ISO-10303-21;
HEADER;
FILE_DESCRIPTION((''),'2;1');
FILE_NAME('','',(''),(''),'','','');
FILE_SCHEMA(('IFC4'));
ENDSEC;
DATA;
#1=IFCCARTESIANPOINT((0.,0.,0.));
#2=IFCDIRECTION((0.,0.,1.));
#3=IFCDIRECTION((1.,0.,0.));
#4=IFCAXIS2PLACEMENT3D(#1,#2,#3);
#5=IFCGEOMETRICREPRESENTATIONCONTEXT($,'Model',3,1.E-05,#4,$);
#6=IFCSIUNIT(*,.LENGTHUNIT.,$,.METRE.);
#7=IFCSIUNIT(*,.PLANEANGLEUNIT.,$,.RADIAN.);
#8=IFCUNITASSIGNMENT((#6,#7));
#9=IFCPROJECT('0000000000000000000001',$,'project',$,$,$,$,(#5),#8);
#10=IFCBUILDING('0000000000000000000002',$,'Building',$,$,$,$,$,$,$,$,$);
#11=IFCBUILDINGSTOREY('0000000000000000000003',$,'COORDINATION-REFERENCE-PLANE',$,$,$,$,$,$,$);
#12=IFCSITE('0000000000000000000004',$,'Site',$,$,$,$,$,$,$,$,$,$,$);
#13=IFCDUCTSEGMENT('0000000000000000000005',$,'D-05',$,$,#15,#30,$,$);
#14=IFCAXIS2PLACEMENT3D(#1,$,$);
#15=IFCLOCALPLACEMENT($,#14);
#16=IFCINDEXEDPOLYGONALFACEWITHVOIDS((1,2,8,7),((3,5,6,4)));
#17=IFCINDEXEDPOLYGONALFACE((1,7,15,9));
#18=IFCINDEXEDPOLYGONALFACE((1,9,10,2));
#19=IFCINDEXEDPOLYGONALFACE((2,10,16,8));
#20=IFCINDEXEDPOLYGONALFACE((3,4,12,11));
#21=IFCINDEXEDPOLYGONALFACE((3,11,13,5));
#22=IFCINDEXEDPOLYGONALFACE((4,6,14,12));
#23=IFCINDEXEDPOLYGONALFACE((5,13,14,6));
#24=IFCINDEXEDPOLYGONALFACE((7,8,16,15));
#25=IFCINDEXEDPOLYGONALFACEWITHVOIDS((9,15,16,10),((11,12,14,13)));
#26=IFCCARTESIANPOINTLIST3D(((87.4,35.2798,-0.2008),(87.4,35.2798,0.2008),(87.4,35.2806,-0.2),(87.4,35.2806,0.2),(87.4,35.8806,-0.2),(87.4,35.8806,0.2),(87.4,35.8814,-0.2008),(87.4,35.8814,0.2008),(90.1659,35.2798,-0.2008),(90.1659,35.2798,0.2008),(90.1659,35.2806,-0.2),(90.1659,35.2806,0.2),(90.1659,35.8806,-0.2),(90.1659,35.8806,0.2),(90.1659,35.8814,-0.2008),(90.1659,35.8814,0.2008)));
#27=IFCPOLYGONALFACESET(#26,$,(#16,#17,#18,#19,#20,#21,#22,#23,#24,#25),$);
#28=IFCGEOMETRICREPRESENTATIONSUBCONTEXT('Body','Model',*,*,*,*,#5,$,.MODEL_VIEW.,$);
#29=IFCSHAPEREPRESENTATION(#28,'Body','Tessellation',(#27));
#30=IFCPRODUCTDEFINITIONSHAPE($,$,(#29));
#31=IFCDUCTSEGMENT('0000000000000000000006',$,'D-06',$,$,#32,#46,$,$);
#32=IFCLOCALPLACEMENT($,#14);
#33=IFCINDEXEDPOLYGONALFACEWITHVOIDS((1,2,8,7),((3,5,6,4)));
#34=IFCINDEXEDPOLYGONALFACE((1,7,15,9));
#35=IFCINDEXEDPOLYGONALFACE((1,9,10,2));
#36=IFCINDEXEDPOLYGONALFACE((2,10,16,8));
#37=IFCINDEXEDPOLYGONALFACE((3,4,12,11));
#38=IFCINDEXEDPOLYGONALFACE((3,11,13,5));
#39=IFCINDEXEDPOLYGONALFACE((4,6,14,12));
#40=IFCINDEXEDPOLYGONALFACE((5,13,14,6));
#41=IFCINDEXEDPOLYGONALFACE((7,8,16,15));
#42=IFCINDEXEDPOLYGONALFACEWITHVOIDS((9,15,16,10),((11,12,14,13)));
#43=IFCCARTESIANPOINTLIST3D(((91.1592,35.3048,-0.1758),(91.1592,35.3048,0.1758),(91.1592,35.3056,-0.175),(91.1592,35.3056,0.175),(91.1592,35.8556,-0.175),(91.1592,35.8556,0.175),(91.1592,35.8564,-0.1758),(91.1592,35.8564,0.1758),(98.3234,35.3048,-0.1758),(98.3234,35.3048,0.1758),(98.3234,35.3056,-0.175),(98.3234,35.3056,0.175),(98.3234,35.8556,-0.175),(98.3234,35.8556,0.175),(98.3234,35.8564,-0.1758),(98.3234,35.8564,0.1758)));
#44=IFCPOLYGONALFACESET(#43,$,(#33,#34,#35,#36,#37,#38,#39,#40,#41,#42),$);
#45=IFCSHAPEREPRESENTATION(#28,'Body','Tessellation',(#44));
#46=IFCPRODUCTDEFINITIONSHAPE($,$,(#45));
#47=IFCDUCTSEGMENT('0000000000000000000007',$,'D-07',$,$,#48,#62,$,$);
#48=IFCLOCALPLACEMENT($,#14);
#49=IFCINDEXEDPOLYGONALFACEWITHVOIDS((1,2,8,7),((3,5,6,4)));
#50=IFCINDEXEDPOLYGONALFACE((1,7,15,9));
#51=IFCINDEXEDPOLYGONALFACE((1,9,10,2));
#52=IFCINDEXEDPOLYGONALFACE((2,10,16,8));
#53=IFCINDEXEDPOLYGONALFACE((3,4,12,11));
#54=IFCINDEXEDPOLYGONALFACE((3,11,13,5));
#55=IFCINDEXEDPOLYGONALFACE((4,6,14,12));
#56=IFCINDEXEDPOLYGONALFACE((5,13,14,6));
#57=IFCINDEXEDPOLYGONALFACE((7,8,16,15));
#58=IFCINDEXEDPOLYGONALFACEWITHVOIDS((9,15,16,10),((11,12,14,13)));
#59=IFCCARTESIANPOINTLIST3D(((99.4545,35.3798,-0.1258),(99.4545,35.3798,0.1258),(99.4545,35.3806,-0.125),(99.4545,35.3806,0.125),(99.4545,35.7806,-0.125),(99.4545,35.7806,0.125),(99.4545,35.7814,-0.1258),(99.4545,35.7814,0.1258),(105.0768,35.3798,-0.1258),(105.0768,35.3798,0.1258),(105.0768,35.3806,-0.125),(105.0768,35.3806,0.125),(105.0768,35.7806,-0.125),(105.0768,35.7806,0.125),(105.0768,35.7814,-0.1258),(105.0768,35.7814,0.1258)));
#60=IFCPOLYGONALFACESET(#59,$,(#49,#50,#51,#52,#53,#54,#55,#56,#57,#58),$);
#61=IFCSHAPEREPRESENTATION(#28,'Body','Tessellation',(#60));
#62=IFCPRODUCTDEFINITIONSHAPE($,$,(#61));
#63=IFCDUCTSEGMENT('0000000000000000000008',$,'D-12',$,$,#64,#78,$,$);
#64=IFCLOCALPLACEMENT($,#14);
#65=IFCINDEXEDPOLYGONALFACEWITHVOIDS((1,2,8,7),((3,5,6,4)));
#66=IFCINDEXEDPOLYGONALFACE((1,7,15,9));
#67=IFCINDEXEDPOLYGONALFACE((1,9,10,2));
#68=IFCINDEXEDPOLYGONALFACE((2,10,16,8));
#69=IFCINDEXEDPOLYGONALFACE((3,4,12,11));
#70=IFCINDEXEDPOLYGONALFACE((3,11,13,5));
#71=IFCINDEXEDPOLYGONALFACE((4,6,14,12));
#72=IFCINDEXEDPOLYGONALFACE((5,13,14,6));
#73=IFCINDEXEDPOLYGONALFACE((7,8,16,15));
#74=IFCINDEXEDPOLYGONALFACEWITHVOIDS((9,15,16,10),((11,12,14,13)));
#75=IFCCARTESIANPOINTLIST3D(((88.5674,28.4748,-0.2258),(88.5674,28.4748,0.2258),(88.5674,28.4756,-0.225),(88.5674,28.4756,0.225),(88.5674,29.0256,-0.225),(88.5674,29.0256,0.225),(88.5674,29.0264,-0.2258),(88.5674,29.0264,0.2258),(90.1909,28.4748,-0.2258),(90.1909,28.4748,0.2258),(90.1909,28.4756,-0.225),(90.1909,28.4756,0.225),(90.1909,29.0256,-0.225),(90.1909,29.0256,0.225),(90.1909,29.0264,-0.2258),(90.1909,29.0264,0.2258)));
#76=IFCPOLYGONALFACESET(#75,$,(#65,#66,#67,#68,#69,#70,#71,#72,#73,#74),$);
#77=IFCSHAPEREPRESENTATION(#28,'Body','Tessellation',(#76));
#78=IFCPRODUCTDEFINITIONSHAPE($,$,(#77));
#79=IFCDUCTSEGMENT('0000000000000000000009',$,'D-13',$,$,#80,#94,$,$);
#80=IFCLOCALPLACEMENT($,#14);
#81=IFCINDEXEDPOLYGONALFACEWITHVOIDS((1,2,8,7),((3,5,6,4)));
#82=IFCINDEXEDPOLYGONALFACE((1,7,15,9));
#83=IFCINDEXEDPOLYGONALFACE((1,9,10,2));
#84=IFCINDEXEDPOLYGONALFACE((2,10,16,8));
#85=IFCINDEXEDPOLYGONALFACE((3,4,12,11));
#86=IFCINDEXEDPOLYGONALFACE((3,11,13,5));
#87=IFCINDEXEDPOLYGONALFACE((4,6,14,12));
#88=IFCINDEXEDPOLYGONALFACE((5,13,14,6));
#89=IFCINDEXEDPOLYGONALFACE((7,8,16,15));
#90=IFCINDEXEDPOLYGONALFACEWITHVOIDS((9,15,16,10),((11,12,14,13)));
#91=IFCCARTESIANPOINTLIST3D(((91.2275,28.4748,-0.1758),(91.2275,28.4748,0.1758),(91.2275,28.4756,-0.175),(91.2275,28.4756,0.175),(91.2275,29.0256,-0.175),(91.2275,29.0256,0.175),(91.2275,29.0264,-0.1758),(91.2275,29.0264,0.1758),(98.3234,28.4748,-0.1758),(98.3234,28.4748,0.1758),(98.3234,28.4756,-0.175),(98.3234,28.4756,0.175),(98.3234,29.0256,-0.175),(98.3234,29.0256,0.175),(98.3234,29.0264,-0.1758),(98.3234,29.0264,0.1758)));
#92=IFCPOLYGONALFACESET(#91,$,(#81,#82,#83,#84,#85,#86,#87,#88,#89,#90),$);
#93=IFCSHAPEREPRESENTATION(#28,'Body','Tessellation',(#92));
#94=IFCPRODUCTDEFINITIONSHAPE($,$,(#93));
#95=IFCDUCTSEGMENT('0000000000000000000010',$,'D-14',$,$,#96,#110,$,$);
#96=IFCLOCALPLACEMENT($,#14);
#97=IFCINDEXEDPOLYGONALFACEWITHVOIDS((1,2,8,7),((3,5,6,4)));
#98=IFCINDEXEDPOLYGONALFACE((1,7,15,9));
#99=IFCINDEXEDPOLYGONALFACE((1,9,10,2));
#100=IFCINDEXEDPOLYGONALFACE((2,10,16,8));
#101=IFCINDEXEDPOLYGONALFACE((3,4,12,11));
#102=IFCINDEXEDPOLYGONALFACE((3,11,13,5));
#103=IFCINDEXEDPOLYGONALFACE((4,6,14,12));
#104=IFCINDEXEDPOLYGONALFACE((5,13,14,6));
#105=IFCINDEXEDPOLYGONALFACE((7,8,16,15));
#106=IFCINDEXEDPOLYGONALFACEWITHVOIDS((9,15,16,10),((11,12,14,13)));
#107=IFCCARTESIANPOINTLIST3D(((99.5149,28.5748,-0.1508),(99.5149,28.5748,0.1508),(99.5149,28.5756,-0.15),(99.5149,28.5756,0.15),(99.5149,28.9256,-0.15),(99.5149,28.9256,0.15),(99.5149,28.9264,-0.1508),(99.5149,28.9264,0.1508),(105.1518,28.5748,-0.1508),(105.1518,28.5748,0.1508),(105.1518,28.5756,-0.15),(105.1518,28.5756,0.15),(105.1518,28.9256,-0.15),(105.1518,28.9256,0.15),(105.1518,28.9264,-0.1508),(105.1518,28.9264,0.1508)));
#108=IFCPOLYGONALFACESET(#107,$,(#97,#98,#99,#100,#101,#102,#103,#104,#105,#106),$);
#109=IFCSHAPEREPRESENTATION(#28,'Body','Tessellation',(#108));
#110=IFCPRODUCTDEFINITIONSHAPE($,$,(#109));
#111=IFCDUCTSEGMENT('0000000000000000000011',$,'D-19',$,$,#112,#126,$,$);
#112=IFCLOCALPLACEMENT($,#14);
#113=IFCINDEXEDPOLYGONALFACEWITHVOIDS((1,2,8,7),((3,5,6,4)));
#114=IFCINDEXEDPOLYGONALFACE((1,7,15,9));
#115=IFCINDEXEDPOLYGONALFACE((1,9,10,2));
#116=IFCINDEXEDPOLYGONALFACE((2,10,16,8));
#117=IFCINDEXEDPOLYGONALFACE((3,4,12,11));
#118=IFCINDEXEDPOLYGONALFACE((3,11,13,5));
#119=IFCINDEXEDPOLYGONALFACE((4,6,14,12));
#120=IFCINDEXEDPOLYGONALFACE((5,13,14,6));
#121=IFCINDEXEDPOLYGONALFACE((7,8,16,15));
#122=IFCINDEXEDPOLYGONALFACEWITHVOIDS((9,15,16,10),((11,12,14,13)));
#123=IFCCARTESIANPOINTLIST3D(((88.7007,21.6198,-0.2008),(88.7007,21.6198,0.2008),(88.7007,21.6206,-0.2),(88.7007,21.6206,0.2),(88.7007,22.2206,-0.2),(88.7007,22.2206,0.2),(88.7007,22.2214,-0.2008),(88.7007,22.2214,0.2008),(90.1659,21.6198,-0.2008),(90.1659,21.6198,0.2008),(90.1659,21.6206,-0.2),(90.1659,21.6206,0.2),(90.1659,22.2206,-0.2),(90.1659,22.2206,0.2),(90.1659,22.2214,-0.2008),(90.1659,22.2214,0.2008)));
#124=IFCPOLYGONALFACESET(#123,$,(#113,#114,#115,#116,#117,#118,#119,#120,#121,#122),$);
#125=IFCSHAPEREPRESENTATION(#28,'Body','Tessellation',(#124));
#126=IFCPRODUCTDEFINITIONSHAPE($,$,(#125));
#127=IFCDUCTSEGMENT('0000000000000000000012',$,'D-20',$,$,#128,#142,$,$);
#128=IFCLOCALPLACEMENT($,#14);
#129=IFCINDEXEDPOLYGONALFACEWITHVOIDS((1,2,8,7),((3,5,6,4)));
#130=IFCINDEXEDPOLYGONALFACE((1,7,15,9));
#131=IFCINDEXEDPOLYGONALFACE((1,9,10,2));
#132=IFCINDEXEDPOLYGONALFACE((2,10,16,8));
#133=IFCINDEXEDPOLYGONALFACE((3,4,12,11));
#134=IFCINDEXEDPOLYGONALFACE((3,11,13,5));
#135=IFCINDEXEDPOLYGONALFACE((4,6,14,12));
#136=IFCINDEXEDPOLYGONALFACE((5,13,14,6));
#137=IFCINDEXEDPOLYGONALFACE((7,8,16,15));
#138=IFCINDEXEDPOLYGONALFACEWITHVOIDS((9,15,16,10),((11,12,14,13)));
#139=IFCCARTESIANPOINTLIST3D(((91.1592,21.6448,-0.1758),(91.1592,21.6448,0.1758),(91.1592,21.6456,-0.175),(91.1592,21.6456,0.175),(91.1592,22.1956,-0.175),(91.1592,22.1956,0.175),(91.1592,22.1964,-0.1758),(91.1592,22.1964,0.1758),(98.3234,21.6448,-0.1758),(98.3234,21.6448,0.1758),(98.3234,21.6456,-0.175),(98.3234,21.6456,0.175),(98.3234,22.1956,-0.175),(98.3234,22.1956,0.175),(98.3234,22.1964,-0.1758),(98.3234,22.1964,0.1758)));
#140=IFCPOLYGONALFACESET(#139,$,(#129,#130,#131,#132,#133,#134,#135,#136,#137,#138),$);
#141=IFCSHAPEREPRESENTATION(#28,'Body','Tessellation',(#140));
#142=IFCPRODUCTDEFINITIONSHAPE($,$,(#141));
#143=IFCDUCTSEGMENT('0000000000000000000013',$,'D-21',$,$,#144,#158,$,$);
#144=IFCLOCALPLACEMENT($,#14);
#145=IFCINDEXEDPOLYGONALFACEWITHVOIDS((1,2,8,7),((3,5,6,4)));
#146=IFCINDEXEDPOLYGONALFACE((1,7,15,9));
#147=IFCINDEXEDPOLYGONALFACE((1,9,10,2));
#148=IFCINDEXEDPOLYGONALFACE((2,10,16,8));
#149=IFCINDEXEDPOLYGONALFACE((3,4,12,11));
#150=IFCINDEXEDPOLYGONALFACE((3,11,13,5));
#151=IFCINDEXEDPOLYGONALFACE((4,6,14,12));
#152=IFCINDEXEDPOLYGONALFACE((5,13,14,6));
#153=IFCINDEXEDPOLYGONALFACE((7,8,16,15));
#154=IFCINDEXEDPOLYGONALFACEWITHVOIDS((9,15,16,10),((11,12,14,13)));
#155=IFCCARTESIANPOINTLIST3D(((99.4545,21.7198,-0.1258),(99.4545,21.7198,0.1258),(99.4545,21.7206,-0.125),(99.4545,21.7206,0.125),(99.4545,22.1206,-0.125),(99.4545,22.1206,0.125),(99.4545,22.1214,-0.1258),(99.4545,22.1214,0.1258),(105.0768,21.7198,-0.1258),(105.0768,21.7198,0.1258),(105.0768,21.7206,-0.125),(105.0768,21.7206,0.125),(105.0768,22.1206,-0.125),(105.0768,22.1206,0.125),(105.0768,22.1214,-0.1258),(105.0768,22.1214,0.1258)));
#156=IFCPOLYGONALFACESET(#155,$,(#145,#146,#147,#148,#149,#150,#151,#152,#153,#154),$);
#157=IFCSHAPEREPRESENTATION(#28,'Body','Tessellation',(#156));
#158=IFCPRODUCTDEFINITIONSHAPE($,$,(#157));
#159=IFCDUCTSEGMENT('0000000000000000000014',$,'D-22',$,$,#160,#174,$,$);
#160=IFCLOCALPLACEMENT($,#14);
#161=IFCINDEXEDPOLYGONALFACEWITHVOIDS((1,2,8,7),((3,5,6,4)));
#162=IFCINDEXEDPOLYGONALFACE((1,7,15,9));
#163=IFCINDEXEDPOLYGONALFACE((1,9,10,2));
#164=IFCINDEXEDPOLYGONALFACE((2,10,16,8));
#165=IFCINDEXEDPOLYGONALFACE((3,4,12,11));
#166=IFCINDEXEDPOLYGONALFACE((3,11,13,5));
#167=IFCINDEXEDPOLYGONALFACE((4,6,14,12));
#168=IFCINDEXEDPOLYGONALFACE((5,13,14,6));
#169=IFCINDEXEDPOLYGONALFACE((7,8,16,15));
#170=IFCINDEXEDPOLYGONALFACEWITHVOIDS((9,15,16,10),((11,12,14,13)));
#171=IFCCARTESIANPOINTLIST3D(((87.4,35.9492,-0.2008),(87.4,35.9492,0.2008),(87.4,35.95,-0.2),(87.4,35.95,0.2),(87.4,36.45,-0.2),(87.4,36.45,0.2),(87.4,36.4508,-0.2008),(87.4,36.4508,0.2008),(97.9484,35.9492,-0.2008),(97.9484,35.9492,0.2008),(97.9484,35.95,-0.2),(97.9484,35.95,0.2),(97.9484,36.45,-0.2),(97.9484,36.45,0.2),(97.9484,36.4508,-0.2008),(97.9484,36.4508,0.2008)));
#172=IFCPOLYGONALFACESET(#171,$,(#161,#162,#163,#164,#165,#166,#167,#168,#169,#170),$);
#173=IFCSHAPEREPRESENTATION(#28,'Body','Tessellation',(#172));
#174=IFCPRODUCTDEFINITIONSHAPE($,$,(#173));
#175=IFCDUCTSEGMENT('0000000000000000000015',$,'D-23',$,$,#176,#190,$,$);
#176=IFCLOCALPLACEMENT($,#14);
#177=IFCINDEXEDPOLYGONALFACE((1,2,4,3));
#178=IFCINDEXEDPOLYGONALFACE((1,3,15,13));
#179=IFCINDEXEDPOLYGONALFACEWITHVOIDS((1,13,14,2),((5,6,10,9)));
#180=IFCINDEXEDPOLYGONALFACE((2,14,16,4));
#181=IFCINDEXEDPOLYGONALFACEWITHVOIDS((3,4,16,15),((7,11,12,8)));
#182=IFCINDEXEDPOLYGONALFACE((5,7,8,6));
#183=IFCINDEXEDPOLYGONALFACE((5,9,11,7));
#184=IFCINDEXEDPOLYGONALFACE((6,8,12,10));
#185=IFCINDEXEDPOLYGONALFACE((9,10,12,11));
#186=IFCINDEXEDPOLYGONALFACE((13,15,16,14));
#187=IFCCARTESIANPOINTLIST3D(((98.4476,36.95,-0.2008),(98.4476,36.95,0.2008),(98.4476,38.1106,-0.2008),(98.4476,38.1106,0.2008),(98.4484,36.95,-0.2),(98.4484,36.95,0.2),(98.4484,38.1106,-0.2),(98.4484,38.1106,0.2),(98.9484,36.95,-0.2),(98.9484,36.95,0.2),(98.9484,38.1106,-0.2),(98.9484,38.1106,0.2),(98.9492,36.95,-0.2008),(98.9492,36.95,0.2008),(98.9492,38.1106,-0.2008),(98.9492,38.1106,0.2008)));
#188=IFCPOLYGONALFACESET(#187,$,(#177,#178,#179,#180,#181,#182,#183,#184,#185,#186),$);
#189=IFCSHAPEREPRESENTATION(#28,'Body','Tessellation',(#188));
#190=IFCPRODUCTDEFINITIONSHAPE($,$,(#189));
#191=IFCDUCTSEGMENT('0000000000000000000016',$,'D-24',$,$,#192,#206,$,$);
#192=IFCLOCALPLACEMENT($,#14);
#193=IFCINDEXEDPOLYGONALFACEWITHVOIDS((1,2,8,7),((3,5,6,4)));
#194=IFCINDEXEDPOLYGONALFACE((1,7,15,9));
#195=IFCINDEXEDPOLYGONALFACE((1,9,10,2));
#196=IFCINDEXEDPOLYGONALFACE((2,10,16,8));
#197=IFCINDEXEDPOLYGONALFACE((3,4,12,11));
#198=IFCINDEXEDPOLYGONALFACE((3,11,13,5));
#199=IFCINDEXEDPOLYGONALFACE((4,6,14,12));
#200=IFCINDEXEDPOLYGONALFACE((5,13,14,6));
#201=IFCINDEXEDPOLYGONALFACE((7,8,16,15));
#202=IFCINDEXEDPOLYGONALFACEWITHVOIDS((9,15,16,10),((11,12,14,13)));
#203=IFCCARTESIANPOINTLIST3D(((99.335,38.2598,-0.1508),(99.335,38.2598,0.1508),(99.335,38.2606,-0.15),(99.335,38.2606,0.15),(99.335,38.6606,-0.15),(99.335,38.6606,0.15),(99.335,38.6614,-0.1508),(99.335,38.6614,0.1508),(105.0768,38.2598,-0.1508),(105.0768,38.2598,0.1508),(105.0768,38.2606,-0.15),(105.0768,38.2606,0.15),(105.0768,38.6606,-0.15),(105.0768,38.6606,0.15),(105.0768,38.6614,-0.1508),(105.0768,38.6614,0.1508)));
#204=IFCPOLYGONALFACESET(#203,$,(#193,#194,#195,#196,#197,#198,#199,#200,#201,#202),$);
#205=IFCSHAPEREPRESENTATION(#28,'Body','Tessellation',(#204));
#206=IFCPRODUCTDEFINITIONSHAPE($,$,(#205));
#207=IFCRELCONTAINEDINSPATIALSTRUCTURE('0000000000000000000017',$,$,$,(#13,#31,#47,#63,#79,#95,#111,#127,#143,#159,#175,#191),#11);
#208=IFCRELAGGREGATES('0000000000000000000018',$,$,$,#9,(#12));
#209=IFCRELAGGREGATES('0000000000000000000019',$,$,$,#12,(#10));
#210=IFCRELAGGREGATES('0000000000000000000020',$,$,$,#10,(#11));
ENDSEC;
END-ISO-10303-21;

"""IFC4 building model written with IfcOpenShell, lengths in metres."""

from ifc_helpers import new_model, si_unit, frame, origin, origin_with_axes, place, context, subcontext, project, spatial, hollow_rectangle, extrude, element, save


model = new_model("IFC4")

# Units and contexts
model_context = context("Model", 3, precision=1e-05, world=origin_with_axes())
body_context = subcontext(model_context, "Body", "Model", "MODEL_VIEW")
ifc_project = project(units=[si_unit("LENGTHUNIT", "METRE"), si_unit("PLANEANGLEUNIT", "RADIAN")], contexts=[model_context])

# Site, building, storey
site = spatial("IfcSite", under=ifc_project, Name="Site")
building = spatial("IfcBuilding", under=site, Name="Building")
storey = spatial("IfcBuildingStorey", under=building, Name="COORDINATION-REFERENCE-PLANE")

# Duct segments
duct_segment_1_placement = place(None, frame((87.4, 35.5806, 0.0), z_axis=(1.0, 0.0, 0.0), x_axis=(0.0, 1.0, 0.0)))
element("IfcDuctSegment", 1, at=duct_segment_1_placement, inside=storey, Name="D-05", context=body_context, shape_type="SweptSolid", body=[
    extrude(hollow_rectangle(XDim=0.6016, YDim=0.4016, WallThickness=0.0008), origin(), (0.0, 0.0, 1.0), 2.7659),
])
duct_segment_2_placement = place(None, frame((91.1592, 35.5806, 0.0), z_axis=(1.0, 0.0, 0.0), x_axis=(0.0, 1.0, 0.0)))
element("IfcDuctSegment", 2, at=duct_segment_2_placement, inside=storey, Name="D-06", context=body_context, shape_type="SweptSolid", body=[
    extrude(hollow_rectangle(XDim=0.5516, YDim=0.3516, WallThickness=0.0008), origin(), (0.0, 0.0, 1.0), 7.1642),
])
duct_segment_3_placement = place(None, frame((99.4545, 35.5806, 0.0), z_axis=(1.0, 0.0, 0.0), x_axis=(0.0, 1.0, 0.0)))
element("IfcDuctSegment", 3, at=duct_segment_3_placement, inside=storey, Name="D-07", context=body_context, shape_type="SweptSolid", body=[
    extrude(hollow_rectangle(XDim=0.4016, YDim=0.2516, WallThickness=0.0008), origin(), (0.0, 0.0, 1.0), 5.6223),
])
duct_segment_4_placement = place(None, frame((88.5674, 28.7506, 0.0), z_axis=(1.0, 0.0, 0.0), x_axis=(0.0, 1.0, 0.0)))
element("IfcDuctSegment", 4, at=duct_segment_4_placement, inside=storey, Name="D-12", context=body_context, shape_type="SweptSolid", body=[
    extrude(hollow_rectangle(XDim=0.5516, YDim=0.4516, WallThickness=0.0008), origin(), (0.0, 0.0, 1.0), 1.6235),
])
duct_segment_5_placement = place(None, frame((91.2275, 28.7506, 0.0), z_axis=(1.0, 0.0, 0.0), x_axis=(0.0, 1.0, 0.0)))
element("IfcDuctSegment", 5, at=duct_segment_5_placement, inside=storey, Name="D-13", context=body_context, shape_type="SweptSolid", body=[
    extrude(hollow_rectangle(XDim=0.5516, YDim=0.3516, WallThickness=0.0008), origin(), (0.0, 0.0, 1.0), 7.0959),
])
duct_segment_6_placement = place(None, frame((99.5149, 28.7506, 0.0), z_axis=(1.0, 0.0, 0.0), x_axis=(0.0, 1.0, 0.0)))
element("IfcDuctSegment", 6, at=duct_segment_6_placement, inside=storey, Name="D-14", context=body_context, shape_type="SweptSolid", body=[
    extrude(hollow_rectangle(XDim=0.3516, YDim=0.3016, WallThickness=0.0008), origin(), (0.0, 0.0, 1.0), 5.6369),
])
duct_segment_7_placement = place(None, frame((88.7007, 21.9206, 0.0), z_axis=(1.0, 0.0, 0.0), x_axis=(0.0, 1.0, 0.0)))
element("IfcDuctSegment", 7, at=duct_segment_7_placement, inside=storey, Name="D-19", context=body_context, shape_type="SweptSolid", body=[
    extrude(hollow_rectangle(XDim=0.6016, YDim=0.4016, WallThickness=0.0008), origin(), (0.0, 0.0, 1.0), 1.4652),
])
duct_segment_8_placement = place(None, frame((91.1592, 21.9206, 0.0), z_axis=(1.0, 0.0, 0.0), x_axis=(0.0, 1.0, 0.0)))
element("IfcDuctSegment", 8, at=duct_segment_8_placement, inside=storey, Name="D-20", context=body_context, shape_type="SweptSolid", body=[
    extrude(hollow_rectangle(XDim=0.5516, YDim=0.3516, WallThickness=0.0008), origin(), (0.0, 0.0, 1.0), 7.1642),
])
duct_segment_9_placement = place(None, frame((99.4545, 21.9206, 0.0), z_axis=(1.0, 0.0, 0.0), x_axis=(0.0, 1.0, 0.0)))
element("IfcDuctSegment", 9, at=duct_segment_9_placement, inside=storey, Name="D-21", context=body_context, shape_type="SweptSolid", body=[
    extrude(hollow_rectangle(XDim=0.4016, YDim=0.2516, WallThickness=0.0008), origin(), (0.0, 0.0, 1.0), 5.6223),
])
duct_segment_10_placement = place(None, frame((87.4, 36.2, 0.0), z_axis=(1.0, 0.0, 0.0), x_axis=(0.0, 1.0, 0.0)))
element("IfcDuctSegment", 10, at=duct_segment_10_placement, inside=storey, Name="D-22", context=body_context, shape_type="SweptSolid", body=[
    extrude(hollow_rectangle(XDim=0.5016, YDim=0.4016, WallThickness=0.0008), origin(), (0.0, 0.0, 1.0), 10.5484),
])
duct_segment_11_placement = place(None, frame((98.6984, 36.95, 0.0), z_axis=(0.0, 1.0, 0.0), x_axis=(1.0, 0.0, 0.0)))
element("IfcDuctSegment", 11, at=duct_segment_11_placement, inside=storey, Name="D-23", context=body_context, shape_type="SweptSolid", body=[
    extrude(hollow_rectangle(XDim=0.5016, YDim=0.4016, WallThickness=0.0008), origin(), (0.0, 0.0, 1.0), 1.1606),
])
duct_segment_12_placement = place(None, frame((99.335, 38.4606, 0.0), z_axis=(1.0, 0.0, 0.0), x_axis=(0.0, 1.0, 0.0)))
element("IfcDuctSegment", 12, at=duct_segment_12_placement, inside=storey, Name="D-24", context=body_context, shape_type="SweptSolid", body=[
    extrude(hollow_rectangle(XDim=0.4016, YDim=0.3016, WallThickness=0.0008), origin(), (0.0, 0.0, 1.0), 5.7417),
])

save(model, "model.ifc")
